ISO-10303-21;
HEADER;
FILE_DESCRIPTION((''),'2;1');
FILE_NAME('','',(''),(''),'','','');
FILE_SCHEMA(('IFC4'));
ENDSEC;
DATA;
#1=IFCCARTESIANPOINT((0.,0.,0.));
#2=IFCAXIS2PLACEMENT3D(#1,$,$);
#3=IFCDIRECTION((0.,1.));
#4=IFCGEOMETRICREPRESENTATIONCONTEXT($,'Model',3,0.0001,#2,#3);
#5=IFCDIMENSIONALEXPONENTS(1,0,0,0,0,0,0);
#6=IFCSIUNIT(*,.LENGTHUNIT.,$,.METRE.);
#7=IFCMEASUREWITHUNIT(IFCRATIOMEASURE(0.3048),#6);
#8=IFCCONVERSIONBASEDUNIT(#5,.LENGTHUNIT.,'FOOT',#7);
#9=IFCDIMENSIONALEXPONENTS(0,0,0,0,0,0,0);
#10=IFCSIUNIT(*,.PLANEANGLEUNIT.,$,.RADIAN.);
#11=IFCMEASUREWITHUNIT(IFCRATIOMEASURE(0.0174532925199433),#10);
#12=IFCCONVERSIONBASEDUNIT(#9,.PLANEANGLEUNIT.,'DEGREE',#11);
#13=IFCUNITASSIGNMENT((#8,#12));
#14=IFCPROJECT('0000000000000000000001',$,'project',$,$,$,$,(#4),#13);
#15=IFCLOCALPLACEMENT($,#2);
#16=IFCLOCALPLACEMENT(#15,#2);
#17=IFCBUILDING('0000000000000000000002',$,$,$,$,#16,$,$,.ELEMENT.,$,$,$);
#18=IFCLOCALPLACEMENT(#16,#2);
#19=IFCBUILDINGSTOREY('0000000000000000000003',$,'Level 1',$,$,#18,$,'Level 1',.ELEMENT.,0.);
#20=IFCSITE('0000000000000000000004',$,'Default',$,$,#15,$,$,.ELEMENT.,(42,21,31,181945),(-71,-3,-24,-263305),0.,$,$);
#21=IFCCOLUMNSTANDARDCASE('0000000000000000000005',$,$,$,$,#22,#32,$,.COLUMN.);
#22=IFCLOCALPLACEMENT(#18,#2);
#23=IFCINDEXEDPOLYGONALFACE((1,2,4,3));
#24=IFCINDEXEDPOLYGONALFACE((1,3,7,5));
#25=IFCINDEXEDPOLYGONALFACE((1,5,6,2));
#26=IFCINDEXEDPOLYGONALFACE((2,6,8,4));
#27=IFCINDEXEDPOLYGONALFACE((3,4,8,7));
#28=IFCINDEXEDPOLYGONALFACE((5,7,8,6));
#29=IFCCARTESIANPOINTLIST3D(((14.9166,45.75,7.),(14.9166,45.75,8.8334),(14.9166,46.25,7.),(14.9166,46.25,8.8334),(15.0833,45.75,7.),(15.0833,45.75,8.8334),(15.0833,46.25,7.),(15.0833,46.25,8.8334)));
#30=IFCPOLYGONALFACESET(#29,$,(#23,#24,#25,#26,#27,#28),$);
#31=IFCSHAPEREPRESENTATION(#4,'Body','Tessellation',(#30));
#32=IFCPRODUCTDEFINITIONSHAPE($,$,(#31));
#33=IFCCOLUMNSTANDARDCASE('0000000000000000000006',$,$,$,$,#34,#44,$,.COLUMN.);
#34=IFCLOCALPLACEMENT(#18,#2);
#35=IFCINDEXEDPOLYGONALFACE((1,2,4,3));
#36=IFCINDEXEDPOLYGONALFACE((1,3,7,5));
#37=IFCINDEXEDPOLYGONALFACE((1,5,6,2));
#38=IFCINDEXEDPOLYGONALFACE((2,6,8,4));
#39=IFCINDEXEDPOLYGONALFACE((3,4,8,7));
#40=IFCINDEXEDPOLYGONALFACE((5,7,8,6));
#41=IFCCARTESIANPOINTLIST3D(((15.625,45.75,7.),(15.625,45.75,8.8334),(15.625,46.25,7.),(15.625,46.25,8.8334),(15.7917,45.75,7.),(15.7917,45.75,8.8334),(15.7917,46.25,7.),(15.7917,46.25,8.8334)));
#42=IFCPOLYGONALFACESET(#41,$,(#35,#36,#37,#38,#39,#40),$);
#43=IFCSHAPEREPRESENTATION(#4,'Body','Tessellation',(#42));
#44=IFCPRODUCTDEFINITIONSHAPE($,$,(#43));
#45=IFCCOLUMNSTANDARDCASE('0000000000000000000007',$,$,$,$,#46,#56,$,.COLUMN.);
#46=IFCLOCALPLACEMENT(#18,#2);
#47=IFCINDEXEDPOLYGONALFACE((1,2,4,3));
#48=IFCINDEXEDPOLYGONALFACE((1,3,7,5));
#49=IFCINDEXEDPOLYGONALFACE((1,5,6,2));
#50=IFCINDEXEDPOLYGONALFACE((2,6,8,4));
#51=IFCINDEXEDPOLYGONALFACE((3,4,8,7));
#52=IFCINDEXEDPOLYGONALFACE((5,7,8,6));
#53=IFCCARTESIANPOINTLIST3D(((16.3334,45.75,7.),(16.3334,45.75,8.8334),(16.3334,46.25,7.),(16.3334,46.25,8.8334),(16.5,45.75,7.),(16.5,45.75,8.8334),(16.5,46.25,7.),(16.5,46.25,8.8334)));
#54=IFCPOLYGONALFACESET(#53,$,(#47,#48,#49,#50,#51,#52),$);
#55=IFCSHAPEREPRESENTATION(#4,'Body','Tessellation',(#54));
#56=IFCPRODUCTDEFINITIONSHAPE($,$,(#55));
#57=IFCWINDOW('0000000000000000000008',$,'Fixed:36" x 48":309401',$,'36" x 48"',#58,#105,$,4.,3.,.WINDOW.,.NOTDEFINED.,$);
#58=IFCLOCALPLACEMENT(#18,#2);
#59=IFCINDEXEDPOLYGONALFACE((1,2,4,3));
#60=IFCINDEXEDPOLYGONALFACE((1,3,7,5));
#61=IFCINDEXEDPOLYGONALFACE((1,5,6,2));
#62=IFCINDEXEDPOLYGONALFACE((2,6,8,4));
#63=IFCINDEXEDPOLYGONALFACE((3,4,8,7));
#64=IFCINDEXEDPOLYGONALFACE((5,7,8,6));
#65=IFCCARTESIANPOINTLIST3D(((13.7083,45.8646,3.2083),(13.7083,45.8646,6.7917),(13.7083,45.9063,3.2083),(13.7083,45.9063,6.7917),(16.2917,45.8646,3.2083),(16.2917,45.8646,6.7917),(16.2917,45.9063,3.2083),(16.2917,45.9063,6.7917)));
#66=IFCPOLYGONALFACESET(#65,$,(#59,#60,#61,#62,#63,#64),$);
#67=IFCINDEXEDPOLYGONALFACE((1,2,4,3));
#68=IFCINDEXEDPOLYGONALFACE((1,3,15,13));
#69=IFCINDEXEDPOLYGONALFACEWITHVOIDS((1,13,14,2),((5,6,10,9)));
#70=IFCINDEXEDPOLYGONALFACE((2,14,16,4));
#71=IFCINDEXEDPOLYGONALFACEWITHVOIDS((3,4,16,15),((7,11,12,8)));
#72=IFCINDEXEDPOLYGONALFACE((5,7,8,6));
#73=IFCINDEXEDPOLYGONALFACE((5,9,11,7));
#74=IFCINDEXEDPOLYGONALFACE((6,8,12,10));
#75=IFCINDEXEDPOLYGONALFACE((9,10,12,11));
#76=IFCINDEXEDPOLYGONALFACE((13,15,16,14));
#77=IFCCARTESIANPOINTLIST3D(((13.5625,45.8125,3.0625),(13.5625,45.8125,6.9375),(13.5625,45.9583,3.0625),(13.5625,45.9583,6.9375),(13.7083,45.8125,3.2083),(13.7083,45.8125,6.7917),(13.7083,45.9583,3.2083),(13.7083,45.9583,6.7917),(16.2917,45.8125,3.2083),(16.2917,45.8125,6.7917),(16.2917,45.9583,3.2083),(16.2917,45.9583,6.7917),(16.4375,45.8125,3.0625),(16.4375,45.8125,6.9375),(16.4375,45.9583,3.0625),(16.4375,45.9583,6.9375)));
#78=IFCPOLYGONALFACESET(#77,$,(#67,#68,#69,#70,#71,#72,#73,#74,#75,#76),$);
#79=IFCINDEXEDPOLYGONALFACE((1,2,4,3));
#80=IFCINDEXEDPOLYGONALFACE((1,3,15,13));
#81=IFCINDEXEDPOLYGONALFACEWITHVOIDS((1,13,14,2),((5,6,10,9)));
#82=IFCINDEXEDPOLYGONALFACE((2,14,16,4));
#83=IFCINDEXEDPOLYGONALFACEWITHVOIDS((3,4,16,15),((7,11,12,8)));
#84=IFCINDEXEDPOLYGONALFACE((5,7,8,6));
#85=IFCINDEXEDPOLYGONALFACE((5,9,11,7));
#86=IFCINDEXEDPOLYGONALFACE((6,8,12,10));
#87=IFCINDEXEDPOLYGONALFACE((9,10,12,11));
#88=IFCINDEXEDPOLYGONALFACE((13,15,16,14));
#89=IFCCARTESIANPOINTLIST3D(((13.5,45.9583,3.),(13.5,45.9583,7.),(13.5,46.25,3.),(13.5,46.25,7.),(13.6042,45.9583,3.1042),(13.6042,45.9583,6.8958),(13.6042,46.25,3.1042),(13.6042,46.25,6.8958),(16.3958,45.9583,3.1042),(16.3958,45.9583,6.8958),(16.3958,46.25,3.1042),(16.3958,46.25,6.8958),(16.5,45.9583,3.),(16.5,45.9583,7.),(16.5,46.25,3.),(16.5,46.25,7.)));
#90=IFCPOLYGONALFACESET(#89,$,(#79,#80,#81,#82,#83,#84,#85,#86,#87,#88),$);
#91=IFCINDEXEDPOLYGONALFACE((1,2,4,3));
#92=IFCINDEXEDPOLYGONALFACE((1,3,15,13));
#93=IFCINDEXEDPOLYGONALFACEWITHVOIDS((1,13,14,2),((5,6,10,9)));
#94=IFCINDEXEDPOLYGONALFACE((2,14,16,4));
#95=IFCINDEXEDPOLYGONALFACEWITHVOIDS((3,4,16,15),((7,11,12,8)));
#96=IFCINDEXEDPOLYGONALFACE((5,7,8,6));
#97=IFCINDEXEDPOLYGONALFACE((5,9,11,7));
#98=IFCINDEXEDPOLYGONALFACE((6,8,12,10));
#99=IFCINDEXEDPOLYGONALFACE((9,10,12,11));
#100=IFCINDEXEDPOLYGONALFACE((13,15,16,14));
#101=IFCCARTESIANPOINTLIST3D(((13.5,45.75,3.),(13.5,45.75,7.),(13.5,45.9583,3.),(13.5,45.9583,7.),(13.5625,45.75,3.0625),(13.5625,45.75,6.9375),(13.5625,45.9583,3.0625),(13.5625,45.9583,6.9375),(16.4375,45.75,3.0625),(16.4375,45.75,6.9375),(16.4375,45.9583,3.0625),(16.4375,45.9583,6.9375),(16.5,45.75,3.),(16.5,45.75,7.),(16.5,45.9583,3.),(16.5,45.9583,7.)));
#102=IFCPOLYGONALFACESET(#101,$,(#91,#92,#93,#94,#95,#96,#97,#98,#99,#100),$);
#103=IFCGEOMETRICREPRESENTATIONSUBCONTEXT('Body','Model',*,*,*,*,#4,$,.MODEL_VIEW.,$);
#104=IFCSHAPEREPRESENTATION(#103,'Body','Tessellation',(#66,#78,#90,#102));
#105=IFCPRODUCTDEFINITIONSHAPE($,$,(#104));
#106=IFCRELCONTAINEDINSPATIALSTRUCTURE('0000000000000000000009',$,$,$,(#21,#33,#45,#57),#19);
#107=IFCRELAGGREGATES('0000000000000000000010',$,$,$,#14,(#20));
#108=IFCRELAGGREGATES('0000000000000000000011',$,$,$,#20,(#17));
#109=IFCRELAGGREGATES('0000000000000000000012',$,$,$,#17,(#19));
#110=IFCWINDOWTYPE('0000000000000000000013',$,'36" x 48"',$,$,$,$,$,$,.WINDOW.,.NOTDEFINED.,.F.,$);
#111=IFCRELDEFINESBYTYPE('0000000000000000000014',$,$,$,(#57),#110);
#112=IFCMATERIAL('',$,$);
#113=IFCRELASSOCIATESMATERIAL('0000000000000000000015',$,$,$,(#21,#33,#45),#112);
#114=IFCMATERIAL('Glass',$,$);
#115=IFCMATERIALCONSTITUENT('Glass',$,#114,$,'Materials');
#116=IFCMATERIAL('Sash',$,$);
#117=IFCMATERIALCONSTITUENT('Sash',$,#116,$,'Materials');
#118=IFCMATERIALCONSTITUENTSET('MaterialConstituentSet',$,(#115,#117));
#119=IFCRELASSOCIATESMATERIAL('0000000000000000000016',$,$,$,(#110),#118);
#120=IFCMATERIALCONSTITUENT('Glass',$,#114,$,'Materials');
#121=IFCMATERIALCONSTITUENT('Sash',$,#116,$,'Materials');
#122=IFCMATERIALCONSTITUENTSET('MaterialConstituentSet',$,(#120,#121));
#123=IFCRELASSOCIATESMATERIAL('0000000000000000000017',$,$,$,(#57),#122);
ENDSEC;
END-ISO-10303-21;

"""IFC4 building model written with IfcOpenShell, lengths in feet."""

from ifc_helpers import new_model, entity, si_unit, converted_unit, direction, frame, frame_2d, origin, place, context, subcontext, project, spatial, polyline, rectangle, outline, extrude, source, transform, mapped, material, constituent, constituent_set, type_object, type_shapes, element, save


model = new_model("IFC4")

# Units and contexts
model_context = context("Model", 3, precision=0.0001, world=origin(), true_north=direction((0.0, 1.0)))
body_context = subcontext(model_context, "Body", "Model", "MODEL_VIEW")
ifc_project = project(units=[converted_unit("LENGTHUNIT", "FOOT", entity("IfcRatioMeasure", 0.3048), si_unit("LENGTHUNIT", "METRE"), dimensions=[1, 0, 0, 0, 0, 0, 0]), converted_unit("PLANEANGLEUNIT", "DEGREE", entity("IfcRatioMeasure", 0.0174532925199433), si_unit("PLANEANGLEUNIT", "RADIAN"), dimensions=[0, 0, 0, 0, 0, 0, 0])], contexts=[model_context])

# Site, building, storey
site_placement = place(None, origin())
site = spatial("IfcSite", under=ifc_project, at=site_placement, Name="Default", CompositionType="ELEMENT", RefLatitude=(42, 21, 31, 181945), RefLongitude=(-71, -3, -24, -263305), RefElevation=0.0)
building_placement = place(site_placement, origin())
building = spatial("IfcBuilding", under=site, at=building_placement, CompositionType="ELEMENT")
storey_placement = place(building_placement, origin())
storey = spatial("IfcBuildingStorey", under=building, at=storey_placement, Name="Level 1", LongName="Level 1", CompositionType="ELEMENT", Elevation=0.0)

# Columns
placement_1 = place(storey_placement, frame((-0.25, 46.0, 0.0)))
ifc_material_1 = material(Name="")
for number, where, z_axis, x_axis in (
    (1, (15.25, 0.0, 7.0), (0.0, 0.0, 1.0), (1.0, 0.0, 0.0)),
    (2, (15.9584, 0.0, 7.0), (0.0, 0.0, 1.0), (1.0, 0.0, 0.0)),
    (3, (16.6667, 0.0, 7.0), (0.0, 0.0, 1.0), (1.0, 0.0, 0.0)),
):
    element("IfcColumnStandardCase", number, at=place(placement_1, frame(where, z_axis=z_axis, x_axis=x_axis)), inside=storey, material=ifc_material_1, PredefinedType="COLUMN", context=model_context, shape_type="SweptSolid", body=[
        extrude(rectangle(XDim=0.1667, YDim=0.5), origin(), (0.0, 0.0, 1.0), 1.8334),
    ])

# Window
ifc_material_2 = material(Name="Glass")
ifc_constituent_1 = constituent(ifc_material_2, Name="Glass", Category="Materials")
ifc_material_3 = material(Name="Sash")
ifc_constituent_2 = constituent(ifc_material_3, Name="Sash", Category="Materials")
ifc_constituent_set_1 = constituent_set(constituents=[ifc_constituent_1, ifc_constituent_2], Name="MaterialConstituentSet")
ifc_constituent_3 = constituent(ifc_material_2, Name="Glass", Category="Materials")
ifc_constituent_4 = constituent(ifc_material_3, Name="Sash", Category="Materials")
ifc_constituent_set_2 = constituent_set(constituents=[ifc_constituent_3, ifc_constituent_4], Name="MaterialConstituentSet")
window_type = type_object("IfcWindowType", Name="36\" x 48\"", ParameterTakesPrecedence=False, PartitioningType="NOTDEFINED", PredefinedType="WINDOW", material=ifc_constituent_set_2)
shared_shape = source(origin(), body_context, "Body", "SweptSolid", [
    extrude(rectangle(XDim=0.0417, YDim=2.5833, at=frame_2d((0.0, 0.0), x_axis=(1.0, 0.0))), frame((1.5, 0.3646, 0.2083), z_axis=(0.0, 0.0, 1.0), x_axis=(0.0, 1.0, 0.0)), (0.0, 0.0, 1.0), 3.5833),
    extrude(outline(polyline([(-1.4375, -1.9375), (1.4375, -1.9375), (1.4375, 1.9375), (-1.4375, 1.9375), (-1.4375, -1.9375)]), holes=[polyline([(-1.2917, -1.7917), (-1.2917, 1.7917), (1.2917, 1.7917), (1.2917, -1.7917), (-1.2917, -1.7917)])]), frame((1.5, 0.2917, 2.0), z_axis=(0.0, 1.0, 0.0), x_axis=(1.0, 0.0, 0.0)), (0.0, 0.0, 1.0), 0.1458),
    extrude(outline(polyline([(-1.5, -2.0), (1.5, -2.0), (1.5, 2.0), (-1.5, 2.0), (-1.5, -2.0)]), holes=[polyline([(-1.3958, -1.8958), (-1.3958, 1.8958), (1.3958, 1.8958), (1.3958, -1.8958), (-1.3958, -1.8958)])]), frame((1.5, 0.0, 2.0), z_axis=(0.0, 1.0, 0.0), x_axis=(1.0, 0.0, 0.0)), (0.0, 0.0, 1.0), 0.2917),
    extrude(outline(polyline([(-2.0, -1.5), (2.0, -1.5), (2.0, 1.5), (-2.0, 1.5), (-2.0, -1.5)]), holes=[polyline([(-1.9375, -1.4375), (-1.9375, 1.4375), (1.9375, 1.4375), (1.9375, -1.4375), (-1.9375, -1.4375)])]), frame((1.5, 0.2917, 2.0), z_axis=(0.0, 1.0, 0.0), x_axis=(0.0, 0.0, -1.0)), (0.0, 0.0, 1.0), 0.2083),
])
type_shapes(window_type, [shared_shape])
placement_2 = place(placement_1, frame((16.75, 0.25, 3.0)))
window_placement = place(placement_2, frame((0.0, 0.0, 0.0), z_axis=(0.0, 0.0, 1.0), x_axis=(-1.0, 0.0, 0.0)))
element("IfcWindow", 4, at=window_placement, inside=storey, type_object=window_type, material=ifc_constituent_set_1, Name="Fixed:36\" x 48\":309401", ObjectType="36\" x 48\"", OverallHeight=4.0, OverallWidth=3.0, PartitioningType="NOTDEFINED", PredefinedType="WINDOW", context=body_context, shape_type="MappedRepresentation", body=[
    mapped(shared_shape, transform((0.0, 0.0, 0.0), scale=1.0)),
])

save(model, "model.ifc")
